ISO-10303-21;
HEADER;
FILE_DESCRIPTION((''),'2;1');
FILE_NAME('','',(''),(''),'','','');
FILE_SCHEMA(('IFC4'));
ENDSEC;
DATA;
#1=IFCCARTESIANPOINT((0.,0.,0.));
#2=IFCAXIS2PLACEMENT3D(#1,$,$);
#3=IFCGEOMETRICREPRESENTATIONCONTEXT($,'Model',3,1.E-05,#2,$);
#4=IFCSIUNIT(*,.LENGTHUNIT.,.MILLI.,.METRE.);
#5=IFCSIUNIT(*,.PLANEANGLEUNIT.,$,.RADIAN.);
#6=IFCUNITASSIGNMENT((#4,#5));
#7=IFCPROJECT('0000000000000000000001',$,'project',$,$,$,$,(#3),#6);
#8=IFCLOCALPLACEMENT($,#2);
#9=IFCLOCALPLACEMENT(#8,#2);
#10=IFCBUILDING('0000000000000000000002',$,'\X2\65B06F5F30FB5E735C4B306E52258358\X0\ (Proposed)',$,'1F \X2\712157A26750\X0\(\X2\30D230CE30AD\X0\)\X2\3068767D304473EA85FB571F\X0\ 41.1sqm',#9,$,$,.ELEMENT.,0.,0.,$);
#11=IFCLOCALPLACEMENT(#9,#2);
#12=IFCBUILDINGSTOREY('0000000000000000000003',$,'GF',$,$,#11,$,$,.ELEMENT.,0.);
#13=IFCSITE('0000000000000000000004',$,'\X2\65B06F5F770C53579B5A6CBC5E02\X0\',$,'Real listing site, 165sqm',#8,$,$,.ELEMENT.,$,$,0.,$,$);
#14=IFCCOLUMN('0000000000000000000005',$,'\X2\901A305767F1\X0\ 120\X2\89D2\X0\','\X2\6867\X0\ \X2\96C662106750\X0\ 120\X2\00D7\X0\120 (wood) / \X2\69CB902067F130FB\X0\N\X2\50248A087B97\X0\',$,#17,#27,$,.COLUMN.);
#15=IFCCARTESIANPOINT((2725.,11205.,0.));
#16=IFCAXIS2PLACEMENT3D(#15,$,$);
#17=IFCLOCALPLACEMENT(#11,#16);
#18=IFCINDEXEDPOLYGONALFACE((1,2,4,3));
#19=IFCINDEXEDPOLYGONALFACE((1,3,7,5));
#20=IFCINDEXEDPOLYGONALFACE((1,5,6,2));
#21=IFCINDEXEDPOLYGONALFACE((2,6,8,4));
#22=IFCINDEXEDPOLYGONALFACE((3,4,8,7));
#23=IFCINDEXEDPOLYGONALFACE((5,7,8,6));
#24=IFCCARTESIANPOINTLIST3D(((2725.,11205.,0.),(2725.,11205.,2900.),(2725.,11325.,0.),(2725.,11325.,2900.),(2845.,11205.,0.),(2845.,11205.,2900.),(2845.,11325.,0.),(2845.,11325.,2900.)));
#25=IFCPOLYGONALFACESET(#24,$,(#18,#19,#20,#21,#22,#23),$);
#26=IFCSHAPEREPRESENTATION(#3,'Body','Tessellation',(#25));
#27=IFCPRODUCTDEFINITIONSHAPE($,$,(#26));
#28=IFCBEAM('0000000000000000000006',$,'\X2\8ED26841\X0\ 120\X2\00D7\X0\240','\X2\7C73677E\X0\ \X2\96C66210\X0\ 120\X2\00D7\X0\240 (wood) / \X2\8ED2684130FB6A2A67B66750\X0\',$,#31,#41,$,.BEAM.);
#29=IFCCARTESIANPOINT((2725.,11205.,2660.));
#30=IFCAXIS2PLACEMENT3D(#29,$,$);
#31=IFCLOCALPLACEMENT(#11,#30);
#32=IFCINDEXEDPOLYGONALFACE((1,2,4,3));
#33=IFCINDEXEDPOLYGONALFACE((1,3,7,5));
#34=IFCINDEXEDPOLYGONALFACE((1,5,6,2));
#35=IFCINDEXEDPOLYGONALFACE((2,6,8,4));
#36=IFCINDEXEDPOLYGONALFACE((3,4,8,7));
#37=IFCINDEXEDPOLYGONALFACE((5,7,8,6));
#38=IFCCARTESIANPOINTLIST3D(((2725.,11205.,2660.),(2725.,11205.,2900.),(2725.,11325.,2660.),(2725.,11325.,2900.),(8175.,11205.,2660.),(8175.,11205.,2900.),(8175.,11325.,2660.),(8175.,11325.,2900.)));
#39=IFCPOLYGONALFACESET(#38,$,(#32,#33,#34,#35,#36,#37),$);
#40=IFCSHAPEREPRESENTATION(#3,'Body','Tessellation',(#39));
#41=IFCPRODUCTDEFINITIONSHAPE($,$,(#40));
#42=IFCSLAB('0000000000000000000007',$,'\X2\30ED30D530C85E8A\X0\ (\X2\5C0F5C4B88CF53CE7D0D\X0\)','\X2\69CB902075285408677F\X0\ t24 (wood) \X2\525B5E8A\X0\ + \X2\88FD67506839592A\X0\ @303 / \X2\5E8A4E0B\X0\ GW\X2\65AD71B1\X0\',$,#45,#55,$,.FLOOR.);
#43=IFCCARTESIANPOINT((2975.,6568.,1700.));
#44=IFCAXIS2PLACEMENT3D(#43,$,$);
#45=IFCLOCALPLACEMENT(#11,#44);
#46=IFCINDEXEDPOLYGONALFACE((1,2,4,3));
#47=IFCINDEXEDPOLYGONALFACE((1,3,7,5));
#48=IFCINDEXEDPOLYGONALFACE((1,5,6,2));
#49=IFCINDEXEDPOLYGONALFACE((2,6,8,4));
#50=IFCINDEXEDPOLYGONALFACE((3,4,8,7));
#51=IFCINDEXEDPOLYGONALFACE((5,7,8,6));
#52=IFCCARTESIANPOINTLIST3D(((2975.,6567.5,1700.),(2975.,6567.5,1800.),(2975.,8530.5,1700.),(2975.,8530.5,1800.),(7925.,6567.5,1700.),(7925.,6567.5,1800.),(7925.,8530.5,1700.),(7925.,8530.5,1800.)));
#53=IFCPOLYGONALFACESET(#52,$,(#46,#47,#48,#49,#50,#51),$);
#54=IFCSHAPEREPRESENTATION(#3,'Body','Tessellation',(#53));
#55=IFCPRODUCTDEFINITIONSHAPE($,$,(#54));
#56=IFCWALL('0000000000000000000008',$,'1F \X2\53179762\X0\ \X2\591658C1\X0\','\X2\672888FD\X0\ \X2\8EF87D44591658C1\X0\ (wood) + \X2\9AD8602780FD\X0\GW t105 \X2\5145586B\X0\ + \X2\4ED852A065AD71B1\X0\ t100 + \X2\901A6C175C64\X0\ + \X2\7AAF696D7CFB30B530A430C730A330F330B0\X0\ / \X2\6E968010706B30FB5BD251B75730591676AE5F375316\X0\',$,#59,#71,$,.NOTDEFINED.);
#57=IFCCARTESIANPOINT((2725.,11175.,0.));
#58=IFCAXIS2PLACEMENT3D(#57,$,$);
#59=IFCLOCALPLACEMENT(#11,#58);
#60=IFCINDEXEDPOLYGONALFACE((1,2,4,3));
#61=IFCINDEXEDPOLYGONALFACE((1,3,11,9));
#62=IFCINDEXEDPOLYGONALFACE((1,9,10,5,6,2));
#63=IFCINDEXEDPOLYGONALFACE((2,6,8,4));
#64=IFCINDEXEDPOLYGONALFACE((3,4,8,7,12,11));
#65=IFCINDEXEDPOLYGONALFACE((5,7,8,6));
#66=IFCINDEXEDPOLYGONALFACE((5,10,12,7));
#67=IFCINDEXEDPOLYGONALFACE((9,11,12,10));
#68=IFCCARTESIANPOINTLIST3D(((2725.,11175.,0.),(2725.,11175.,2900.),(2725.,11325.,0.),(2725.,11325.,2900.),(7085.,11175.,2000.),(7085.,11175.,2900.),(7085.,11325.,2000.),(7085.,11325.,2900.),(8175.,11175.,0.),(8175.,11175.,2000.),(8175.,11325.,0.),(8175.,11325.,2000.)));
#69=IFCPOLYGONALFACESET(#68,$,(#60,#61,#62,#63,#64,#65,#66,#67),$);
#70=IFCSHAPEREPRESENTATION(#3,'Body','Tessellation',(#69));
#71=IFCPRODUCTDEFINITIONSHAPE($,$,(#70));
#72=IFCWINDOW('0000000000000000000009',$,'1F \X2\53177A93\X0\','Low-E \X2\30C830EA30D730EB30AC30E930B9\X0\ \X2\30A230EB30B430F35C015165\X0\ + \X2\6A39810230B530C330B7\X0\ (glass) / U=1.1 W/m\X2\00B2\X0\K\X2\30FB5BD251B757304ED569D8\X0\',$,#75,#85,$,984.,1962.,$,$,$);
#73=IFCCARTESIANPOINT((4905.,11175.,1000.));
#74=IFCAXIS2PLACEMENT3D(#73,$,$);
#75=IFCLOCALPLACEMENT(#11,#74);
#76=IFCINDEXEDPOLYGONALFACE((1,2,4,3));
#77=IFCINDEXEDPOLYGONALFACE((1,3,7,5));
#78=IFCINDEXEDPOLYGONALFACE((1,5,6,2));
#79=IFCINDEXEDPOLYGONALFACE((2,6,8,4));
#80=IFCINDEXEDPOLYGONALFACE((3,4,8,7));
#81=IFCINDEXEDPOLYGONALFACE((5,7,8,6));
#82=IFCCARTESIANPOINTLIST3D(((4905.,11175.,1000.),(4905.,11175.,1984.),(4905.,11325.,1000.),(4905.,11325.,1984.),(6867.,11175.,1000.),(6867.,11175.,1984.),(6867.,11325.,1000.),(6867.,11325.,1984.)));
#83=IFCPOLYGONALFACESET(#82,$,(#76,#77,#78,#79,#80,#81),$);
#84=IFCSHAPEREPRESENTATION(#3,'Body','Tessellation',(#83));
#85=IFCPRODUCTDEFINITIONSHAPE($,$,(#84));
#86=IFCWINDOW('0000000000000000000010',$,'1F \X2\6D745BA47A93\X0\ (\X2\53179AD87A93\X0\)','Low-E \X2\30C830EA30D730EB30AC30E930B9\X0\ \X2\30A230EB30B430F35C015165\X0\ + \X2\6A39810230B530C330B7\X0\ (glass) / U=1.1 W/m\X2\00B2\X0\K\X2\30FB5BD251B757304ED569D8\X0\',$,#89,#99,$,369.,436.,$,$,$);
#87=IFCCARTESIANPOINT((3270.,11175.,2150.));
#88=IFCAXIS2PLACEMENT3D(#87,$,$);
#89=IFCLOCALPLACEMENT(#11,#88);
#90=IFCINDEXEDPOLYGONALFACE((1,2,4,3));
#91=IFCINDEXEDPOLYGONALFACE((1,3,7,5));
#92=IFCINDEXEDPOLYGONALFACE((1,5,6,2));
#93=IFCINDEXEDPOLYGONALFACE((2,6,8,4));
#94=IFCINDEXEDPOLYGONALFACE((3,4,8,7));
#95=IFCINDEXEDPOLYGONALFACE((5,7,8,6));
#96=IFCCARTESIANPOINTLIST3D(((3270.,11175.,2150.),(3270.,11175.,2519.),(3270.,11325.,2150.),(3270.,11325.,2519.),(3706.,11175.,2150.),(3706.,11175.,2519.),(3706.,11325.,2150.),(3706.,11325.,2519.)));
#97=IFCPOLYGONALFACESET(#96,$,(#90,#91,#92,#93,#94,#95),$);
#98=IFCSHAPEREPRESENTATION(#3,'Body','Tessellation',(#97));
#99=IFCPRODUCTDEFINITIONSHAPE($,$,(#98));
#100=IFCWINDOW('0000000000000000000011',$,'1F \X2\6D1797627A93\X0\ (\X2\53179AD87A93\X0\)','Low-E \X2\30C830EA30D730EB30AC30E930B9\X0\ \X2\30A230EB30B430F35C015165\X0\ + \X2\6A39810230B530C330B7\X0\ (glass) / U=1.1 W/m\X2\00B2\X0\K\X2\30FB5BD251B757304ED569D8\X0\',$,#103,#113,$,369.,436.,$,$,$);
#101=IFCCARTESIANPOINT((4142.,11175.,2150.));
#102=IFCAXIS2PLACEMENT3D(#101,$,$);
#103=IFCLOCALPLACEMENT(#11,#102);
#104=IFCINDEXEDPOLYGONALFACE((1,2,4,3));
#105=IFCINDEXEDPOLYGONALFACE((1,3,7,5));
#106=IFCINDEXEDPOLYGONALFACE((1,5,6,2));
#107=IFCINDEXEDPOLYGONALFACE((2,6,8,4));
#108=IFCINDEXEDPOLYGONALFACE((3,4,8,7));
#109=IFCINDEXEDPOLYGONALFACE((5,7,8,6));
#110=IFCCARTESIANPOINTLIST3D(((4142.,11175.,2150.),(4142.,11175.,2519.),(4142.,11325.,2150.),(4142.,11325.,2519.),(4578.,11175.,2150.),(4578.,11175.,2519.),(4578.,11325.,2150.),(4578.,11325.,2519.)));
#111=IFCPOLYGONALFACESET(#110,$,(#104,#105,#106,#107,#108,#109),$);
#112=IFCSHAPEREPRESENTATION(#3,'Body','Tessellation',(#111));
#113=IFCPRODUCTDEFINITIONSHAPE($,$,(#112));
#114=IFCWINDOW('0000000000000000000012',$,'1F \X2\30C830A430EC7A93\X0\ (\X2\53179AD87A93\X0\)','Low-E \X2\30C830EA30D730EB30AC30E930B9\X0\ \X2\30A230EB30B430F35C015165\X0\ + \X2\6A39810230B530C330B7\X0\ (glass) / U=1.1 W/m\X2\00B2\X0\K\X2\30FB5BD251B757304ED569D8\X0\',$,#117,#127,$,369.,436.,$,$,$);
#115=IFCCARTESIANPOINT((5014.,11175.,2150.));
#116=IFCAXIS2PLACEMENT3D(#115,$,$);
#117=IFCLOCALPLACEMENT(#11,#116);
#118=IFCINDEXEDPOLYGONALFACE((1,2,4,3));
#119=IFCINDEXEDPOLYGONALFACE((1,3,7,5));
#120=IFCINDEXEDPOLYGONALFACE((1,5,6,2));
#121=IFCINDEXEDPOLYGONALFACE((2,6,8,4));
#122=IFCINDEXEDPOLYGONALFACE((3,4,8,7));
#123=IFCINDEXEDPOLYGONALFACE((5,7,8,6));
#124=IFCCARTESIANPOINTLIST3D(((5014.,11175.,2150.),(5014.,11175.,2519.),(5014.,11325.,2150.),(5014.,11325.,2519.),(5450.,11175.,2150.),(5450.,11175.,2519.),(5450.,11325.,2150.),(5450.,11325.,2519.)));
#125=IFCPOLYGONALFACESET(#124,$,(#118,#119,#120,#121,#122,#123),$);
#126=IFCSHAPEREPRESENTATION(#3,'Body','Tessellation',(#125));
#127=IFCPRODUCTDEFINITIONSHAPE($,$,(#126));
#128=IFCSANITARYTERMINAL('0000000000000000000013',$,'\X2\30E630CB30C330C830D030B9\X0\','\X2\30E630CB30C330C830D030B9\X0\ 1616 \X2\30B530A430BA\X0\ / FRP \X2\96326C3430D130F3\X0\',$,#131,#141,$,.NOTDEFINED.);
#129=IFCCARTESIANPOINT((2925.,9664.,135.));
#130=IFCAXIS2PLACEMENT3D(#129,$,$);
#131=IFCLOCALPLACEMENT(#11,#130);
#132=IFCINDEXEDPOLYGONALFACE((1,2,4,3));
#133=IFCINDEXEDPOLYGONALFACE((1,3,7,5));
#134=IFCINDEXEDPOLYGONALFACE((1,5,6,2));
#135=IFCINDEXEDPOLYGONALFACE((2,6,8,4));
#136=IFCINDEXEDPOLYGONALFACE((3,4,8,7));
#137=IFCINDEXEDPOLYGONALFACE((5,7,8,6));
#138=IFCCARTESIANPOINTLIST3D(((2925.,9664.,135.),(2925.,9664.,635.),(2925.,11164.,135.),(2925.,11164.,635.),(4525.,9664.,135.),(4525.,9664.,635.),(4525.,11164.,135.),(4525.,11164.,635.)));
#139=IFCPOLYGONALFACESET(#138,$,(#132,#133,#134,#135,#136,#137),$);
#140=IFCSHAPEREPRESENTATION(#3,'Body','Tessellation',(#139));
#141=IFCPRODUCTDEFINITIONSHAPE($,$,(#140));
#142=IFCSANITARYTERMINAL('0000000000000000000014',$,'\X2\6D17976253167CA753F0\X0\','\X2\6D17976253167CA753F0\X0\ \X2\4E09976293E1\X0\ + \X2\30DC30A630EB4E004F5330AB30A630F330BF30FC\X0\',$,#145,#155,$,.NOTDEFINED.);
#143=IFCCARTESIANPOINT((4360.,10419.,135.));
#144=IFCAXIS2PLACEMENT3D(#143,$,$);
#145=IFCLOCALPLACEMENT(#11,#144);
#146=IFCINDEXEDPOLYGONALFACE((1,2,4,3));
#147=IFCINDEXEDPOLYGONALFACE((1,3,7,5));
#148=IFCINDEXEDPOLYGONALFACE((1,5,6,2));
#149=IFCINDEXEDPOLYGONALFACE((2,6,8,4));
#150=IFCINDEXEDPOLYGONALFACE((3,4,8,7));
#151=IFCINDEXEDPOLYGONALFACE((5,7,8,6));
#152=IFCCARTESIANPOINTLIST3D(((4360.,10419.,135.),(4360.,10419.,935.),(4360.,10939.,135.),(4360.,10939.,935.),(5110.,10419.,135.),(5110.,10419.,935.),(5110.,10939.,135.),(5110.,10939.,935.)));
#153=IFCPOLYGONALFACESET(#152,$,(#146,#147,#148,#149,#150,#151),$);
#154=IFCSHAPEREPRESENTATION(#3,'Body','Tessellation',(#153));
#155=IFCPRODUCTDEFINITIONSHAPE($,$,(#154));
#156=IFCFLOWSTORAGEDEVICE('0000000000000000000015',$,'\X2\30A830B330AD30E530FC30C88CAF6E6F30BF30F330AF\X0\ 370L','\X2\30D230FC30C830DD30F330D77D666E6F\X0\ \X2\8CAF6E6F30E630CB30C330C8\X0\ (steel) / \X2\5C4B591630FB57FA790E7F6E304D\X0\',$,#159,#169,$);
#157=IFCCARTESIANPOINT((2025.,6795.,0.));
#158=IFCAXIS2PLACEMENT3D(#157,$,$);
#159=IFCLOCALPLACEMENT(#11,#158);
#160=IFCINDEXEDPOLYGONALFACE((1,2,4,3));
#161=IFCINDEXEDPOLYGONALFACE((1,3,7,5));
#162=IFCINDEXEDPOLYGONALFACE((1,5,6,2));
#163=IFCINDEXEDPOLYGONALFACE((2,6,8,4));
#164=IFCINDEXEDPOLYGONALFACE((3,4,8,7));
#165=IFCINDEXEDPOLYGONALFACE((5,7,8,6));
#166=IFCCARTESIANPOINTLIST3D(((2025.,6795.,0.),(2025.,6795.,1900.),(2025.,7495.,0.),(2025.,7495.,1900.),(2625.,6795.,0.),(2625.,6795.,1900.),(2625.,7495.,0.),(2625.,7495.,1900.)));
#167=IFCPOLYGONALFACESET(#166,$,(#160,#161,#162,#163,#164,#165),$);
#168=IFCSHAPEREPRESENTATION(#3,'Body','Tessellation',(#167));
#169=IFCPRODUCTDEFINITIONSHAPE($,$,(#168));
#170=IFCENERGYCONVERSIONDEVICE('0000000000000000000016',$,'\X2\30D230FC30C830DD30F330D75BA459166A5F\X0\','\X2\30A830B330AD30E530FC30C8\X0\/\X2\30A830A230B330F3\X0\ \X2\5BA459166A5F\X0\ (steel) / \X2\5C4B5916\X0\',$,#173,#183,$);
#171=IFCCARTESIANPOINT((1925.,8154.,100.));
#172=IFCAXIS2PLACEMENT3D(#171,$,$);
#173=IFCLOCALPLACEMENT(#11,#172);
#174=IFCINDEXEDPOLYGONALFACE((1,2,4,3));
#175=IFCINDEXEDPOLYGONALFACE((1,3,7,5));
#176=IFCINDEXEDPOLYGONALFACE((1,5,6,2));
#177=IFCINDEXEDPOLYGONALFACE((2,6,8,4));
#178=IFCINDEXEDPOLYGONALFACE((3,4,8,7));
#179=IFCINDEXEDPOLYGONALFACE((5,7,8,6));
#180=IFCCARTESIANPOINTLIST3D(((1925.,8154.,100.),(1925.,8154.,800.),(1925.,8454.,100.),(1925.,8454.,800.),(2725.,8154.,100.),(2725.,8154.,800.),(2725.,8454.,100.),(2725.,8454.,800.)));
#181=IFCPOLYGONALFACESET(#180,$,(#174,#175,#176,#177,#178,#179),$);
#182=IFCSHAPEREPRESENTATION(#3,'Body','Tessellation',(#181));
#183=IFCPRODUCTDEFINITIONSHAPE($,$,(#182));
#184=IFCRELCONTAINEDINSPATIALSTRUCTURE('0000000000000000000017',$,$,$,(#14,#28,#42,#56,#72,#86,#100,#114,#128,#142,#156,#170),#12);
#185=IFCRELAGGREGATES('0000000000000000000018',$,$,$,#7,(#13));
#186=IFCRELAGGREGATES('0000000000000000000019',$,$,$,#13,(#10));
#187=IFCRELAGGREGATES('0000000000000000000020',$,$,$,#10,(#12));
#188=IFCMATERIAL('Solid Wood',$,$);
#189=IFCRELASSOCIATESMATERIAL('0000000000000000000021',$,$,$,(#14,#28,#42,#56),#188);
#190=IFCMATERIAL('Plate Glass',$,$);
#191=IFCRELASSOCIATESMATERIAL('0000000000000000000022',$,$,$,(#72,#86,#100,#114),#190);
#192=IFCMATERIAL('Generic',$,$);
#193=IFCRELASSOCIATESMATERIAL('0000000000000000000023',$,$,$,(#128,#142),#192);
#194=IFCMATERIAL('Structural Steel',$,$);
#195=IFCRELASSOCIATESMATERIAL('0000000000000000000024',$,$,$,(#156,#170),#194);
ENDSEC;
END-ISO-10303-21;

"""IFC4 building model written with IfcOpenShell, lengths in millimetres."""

from ifc_helpers import new_model, si_unit, frame, frame_2d, origin, place, context, project, spatial, rectangle, extrude, material, element, fill, save


model = new_model("IFC4")

# Units and contexts
model_context = context("Model", 3, precision=1e-05, world=origin())
ifc_project = project(units=[si_unit("LENGTHUNIT", "METRE", prefix="MILLI"), si_unit("PLANEANGLEUNIT", "RADIAN")], contexts=[model_context])

# Site, building, storey
site_placement = place(None, origin())
site = spatial("IfcSite", under=ifc_project, at=site_placement, Name="新潟県南魚沼市", ObjectType="Real listing site, 165sqm", CompositionType="ELEMENT", RefElevation=0.0)
building_placement = place(site_placement, origin())
building = spatial("IfcBuilding", under=site, at=building_placement, Name="新潟・平屋の別荘 (Proposed)", ObjectType="1F 無垢材(ヒノキ)と白い珪藻土 41.1sqm", CompositionType="ELEMENT", ElevationOfRefHeight=0.0, ElevationOfTerrain=0.0)
storey_placement = place(building_placement, origin())
storey = spatial("IfcBuildingStorey", under=building, at=storey_placement, Name="GF", CompositionType="ELEMENT", Elevation=0.0)

# Column
ifc_material_1 = material(Name="Solid Wood")
column_1_placement = place(storey_placement, frame((2725.0, 11205.0, 0.0)))
element("IfcColumn", 1, at=column_1_placement, inside=storey, material=ifc_material_1, Name="通し柱 120角", Description="桧 集成材 120×120 (wood) / 構造柱・N値計算", PredefinedType="COLUMN", context=model_context, shape_type="SweptSolid", body=[
    extrude(rectangle(XDim=120.0, YDim=120.0, at=frame_2d((60.0, 60.0))), frame((2725.0, 11205.0, 0.0)), (0.0, 0.0, 1.0), 2900.0),
])

# Beam
beam_1_placement = place(storey_placement, frame((2725.0, 11205.0, 2660.0)))
element("IfcBeam", 2, at=beam_1_placement, inside=storey, material=ifc_material_1, Name="軒桁 120×240", Description="米松 集成 120×240 (wood) / 軒桁・横架材", PredefinedType="BEAM", context=model_context, shape_type="SweptSolid", body=[
    extrude(rectangle(XDim=5450.0, YDim=120.0, at=frame_2d((2725.0, 60.0))), frame((2725.0, 11205.0, 2660.0)), (0.0, 0.0, 1.0), 240.0),
])

# Slab
slab_placement = place(storey_placement, frame((2975.0, 6568.0, 1700.0)))
element("IfcSlab", 3, at=slab_placement, inside=storey, material=ifc_material_1, Name="ロフト床 (小屋裏収納)", Description="構造用合板 t24 (wood) 剛床 + 製材根太 @303 / 床下 GW断熱", PredefinedType="FLOOR", context=model_context, shape_type="SweptSolid", body=[
    extrude(rectangle(XDim=4950.0, YDim=1963.0, at=frame_2d((2475.0, 981.0))), frame((2975.0, 6568.0, 1700.0)), (0.0, 0.0, 1.0), 100.0),
])

# Wall, openings, windows
wall_1_placement = place(storey_placement, frame((2725.0, 11175.0, 0.0)))
wall_1 = element("IfcWall", 4, at=wall_1_placement, inside=storey, material=ifc_material_1, Name="1F 北面 外壁", Description="木製 軸組外壁 (wood) + 高性能GW t105 充填 + 付加断熱 t100 + 通気層 + 窯業系サイディング / 準耐火・寒冷地外皮強化", PredefinedType="NOTDEFINED", context=model_context, shape_type="SweptSolid", body=[
    extrude(rectangle(XDim=5450.0, YDim=150.0, at=frame_2d((2725.0, 75.0))), frame((2725.0, 11175.0, 0.0)), (0.0, 0.0, 1.0), 2900.0),
])
opening_1_placement = place(storey_placement, frame((4905.0, 11175.0, 1000.0)))
opening_1 = element("IfcOpeningElement", 5, at=opening_1_placement, cuts=wall_1, PredefinedType="NOTDEFINED", context=model_context, shape_type="SweptSolid", body=[
    extrude(rectangle(XDim=1962.0, YDim=150.0, at=frame_2d((981.0, 75.0))), frame((4905.0, 11175.0, 1000.0)), (0.0, 0.0, 1.0), 984.0),
])
opening_2_placement = place(storey_placement, frame((3270.0, 11175.0, 2150.0)))
opening_2 = element("IfcOpeningElement", 6, at=opening_2_placement, cuts=wall_1, PredefinedType="NOTDEFINED", context=model_context, shape_type="SweptSolid", body=[
    extrude(rectangle(XDim=436.0, YDim=150.0, at=frame_2d((218.0, 75.0))), frame((3270.0, 11175.0, 2150.0)), (0.0, 0.0, 1.0), 369.0),
])
opening_3_placement = place(storey_placement, frame((4142.0, 11175.0, 2150.0)))
opening_3 = element("IfcOpeningElement", 7, at=opening_3_placement, cuts=wall_1, PredefinedType="NOTDEFINED", context=model_context, shape_type="SweptSolid", body=[
    extrude(rectangle(XDim=436.0, YDim=150.0, at=frame_2d((218.0, 75.0))), frame((4142.0, 11175.0, 2150.0)), (0.0, 0.0, 1.0), 369.0),
])
opening_4_placement = place(storey_placement, frame((5014.0, 11175.0, 2150.0)))
opening_4 = element("IfcOpeningElement", 8, at=opening_4_placement, cuts=wall_1, PredefinedType="NOTDEFINED", context=model_context, shape_type="SweptSolid", body=[
    extrude(rectangle(XDim=436.0, YDim=150.0, at=frame_2d((218.0, 75.0))), frame((5014.0, 11175.0, 2150.0)), (0.0, 0.0, 1.0), 369.0),
])
ifc_material_2 = material(Name="Plate Glass")
window_1_placement = place(storey_placement, frame((4905.0, 11175.0, 1000.0)))
window_1 = element("IfcWindow", 9, at=window_1_placement, inside=storey, material=ifc_material_2, Name="1F 北窓", Description="Low-E トリプルガラス アルゴン封入 + 樹脂サッシ (glass) / U=1.1 W/m²K・寒冷地仕様", OverallHeight=984.0, OverallWidth=1962.0, context=model_context, shape_type="SweptSolid", body=[
    extrude(rectangle(XDim=1962.0, YDim=150.0, at=frame_2d((981.0, 75.0))), frame((4905.0, 11175.0, 1000.0)), (0.0, 0.0, 1.0), 984.0),
])
fill(opening_1, window_1)
window_2_placement = place(storey_placement, frame((3270.0, 11175.0, 2150.0)))
window_2 = element("IfcWindow", 10, at=window_2_placement, inside=storey, material=ifc_material_2, Name="1F 浴室窓 (北高窓)", Description="Low-E トリプルガラス アルゴン封入 + 樹脂サッシ (glass) / U=1.1 W/m²K・寒冷地仕様", OverallHeight=369.0, OverallWidth=436.0, context=model_context, shape_type="SweptSolid", body=[
    extrude(rectangle(XDim=436.0, YDim=150.0, at=frame_2d((218.0, 75.0))), frame((3270.0, 11175.0, 2150.0)), (0.0, 0.0, 1.0), 369.0),
])
fill(opening_2, window_2)
window_3_placement = place(storey_placement, frame((4142.0, 11175.0, 2150.0)))
window_3 = element("IfcWindow", 11, at=window_3_placement, inside=storey, material=ifc_material_2, Name="1F 洗面窓 (北高窓)", Description="Low-E トリプルガラス アルゴン封入 + 樹脂サッシ (glass) / U=1.1 W/m²K・寒冷地仕様", OverallHeight=369.0, OverallWidth=436.0, context=model_context, shape_type="SweptSolid", body=[
    extrude(rectangle(XDim=436.0, YDim=150.0, at=frame_2d((218.0, 75.0))), frame((4142.0, 11175.0, 2150.0)), (0.0, 0.0, 1.0), 369.0),
])
fill(opening_3, window_3)
window_4_placement = place(storey_placement, frame((5014.0, 11175.0, 2150.0)))
window_4 = element("IfcWindow", 12, at=window_4_placement, inside=storey, material=ifc_material_2, Name="1F トイレ窓 (北高窓)", Description="Low-E トリプルガラス アルゴン封入 + 樹脂サッシ (glass) / U=1.1 W/m²K・寒冷地仕様", OverallHeight=369.0, OverallWidth=436.0, context=model_context, shape_type="SweptSolid", body=[
    extrude(rectangle(XDim=436.0, YDim=150.0, at=frame_2d((218.0, 75.0))), frame((5014.0, 11175.0, 2150.0)), (0.0, 0.0, 1.0), 369.0),
])
fill(opening_4, window_4)

# Sanitary terminals
ifc_material_3 = material(Name="Generic")
sanitary_terminal_1_placement = place(storey_placement, frame((2925.0, 9664.0, 135.0)))
element("IfcSanitaryTerminal", 13, at=sanitary_terminal_1_placement, inside=storey, material=ifc_material_3, Name="ユニットバス", Description="ユニットバス 1616 サイズ / FRP 防水パン", PredefinedType="NOTDEFINED", context=model_context, shape_type="SweptSolid", body=[
    extrude(rectangle(XDim=1600.0, YDim=1500.0, at=frame_2d((800.0, 750.0))), frame((2925.0, 9664.0, 135.0)), (0.0, 0.0, 1.0), 500.0),
])
sanitary_terminal_2_placement = place(storey_placement, frame((4360.0, 10419.0, 135.0)))
element("IfcSanitaryTerminal", 14, at=sanitary_terminal_2_placement, inside=storey, material=ifc_material_3, Name="洗面化粧台", Description="洗面化粧台 三面鏡 + ボウル一体カウンター", PredefinedType="NOTDEFINED", context=model_context, shape_type="SweptSolid", body=[
    extrude(rectangle(XDim=750.0, YDim=520.0, at=frame_2d((375.0, 260.0))), frame((4360.0, 10419.0, 135.0)), (0.0, 0.0, 1.0), 800.0),
])

# Flow storage device
ifc_material_4 = material(Name="Structural Steel")
flow_storage_device_placement = place(storey_placement, frame((2025.0, 6795.0, 0.0)))
element("IfcFlowStorageDevice", 15, at=flow_storage_device_placement, inside=storey, material=ifc_material_4, Name="エコキュート貯湯タンク 370L", Description="ヒートポンプ給湯 貯湯ユニット (steel) / 屋外・基礎置き", context=model_context, shape_type="SweptSolid", body=[
    extrude(rectangle(XDim=600.0, YDim=700.0, at=frame_2d((300.0, 350.0))), frame((2025.0, 6795.0, 0.0)), (0.0, 0.0, 1.0), 1900.0),
])

# Energy conversion device
energy_conversion_device_placement = place(storey_placement, frame((1925.0, 8154.0, 100.0)))
element("IfcEnergyConversionDevice", 16, at=energy_conversion_device_placement, inside=storey, material=ifc_material_4, Name="ヒートポンプ室外機", Description="エコキュート/エアコン 室外機 (steel) / 屋外", context=model_context, shape_type="SweptSolid", body=[
    extrude(rectangle(XDim=800.0, YDim=300.0, at=frame_2d((400.0, 150.0))), frame((1925.0, 8154.0, 100.0)), (0.0, 0.0, 1.0), 700.0),
])

save(model, "model.ifc")
